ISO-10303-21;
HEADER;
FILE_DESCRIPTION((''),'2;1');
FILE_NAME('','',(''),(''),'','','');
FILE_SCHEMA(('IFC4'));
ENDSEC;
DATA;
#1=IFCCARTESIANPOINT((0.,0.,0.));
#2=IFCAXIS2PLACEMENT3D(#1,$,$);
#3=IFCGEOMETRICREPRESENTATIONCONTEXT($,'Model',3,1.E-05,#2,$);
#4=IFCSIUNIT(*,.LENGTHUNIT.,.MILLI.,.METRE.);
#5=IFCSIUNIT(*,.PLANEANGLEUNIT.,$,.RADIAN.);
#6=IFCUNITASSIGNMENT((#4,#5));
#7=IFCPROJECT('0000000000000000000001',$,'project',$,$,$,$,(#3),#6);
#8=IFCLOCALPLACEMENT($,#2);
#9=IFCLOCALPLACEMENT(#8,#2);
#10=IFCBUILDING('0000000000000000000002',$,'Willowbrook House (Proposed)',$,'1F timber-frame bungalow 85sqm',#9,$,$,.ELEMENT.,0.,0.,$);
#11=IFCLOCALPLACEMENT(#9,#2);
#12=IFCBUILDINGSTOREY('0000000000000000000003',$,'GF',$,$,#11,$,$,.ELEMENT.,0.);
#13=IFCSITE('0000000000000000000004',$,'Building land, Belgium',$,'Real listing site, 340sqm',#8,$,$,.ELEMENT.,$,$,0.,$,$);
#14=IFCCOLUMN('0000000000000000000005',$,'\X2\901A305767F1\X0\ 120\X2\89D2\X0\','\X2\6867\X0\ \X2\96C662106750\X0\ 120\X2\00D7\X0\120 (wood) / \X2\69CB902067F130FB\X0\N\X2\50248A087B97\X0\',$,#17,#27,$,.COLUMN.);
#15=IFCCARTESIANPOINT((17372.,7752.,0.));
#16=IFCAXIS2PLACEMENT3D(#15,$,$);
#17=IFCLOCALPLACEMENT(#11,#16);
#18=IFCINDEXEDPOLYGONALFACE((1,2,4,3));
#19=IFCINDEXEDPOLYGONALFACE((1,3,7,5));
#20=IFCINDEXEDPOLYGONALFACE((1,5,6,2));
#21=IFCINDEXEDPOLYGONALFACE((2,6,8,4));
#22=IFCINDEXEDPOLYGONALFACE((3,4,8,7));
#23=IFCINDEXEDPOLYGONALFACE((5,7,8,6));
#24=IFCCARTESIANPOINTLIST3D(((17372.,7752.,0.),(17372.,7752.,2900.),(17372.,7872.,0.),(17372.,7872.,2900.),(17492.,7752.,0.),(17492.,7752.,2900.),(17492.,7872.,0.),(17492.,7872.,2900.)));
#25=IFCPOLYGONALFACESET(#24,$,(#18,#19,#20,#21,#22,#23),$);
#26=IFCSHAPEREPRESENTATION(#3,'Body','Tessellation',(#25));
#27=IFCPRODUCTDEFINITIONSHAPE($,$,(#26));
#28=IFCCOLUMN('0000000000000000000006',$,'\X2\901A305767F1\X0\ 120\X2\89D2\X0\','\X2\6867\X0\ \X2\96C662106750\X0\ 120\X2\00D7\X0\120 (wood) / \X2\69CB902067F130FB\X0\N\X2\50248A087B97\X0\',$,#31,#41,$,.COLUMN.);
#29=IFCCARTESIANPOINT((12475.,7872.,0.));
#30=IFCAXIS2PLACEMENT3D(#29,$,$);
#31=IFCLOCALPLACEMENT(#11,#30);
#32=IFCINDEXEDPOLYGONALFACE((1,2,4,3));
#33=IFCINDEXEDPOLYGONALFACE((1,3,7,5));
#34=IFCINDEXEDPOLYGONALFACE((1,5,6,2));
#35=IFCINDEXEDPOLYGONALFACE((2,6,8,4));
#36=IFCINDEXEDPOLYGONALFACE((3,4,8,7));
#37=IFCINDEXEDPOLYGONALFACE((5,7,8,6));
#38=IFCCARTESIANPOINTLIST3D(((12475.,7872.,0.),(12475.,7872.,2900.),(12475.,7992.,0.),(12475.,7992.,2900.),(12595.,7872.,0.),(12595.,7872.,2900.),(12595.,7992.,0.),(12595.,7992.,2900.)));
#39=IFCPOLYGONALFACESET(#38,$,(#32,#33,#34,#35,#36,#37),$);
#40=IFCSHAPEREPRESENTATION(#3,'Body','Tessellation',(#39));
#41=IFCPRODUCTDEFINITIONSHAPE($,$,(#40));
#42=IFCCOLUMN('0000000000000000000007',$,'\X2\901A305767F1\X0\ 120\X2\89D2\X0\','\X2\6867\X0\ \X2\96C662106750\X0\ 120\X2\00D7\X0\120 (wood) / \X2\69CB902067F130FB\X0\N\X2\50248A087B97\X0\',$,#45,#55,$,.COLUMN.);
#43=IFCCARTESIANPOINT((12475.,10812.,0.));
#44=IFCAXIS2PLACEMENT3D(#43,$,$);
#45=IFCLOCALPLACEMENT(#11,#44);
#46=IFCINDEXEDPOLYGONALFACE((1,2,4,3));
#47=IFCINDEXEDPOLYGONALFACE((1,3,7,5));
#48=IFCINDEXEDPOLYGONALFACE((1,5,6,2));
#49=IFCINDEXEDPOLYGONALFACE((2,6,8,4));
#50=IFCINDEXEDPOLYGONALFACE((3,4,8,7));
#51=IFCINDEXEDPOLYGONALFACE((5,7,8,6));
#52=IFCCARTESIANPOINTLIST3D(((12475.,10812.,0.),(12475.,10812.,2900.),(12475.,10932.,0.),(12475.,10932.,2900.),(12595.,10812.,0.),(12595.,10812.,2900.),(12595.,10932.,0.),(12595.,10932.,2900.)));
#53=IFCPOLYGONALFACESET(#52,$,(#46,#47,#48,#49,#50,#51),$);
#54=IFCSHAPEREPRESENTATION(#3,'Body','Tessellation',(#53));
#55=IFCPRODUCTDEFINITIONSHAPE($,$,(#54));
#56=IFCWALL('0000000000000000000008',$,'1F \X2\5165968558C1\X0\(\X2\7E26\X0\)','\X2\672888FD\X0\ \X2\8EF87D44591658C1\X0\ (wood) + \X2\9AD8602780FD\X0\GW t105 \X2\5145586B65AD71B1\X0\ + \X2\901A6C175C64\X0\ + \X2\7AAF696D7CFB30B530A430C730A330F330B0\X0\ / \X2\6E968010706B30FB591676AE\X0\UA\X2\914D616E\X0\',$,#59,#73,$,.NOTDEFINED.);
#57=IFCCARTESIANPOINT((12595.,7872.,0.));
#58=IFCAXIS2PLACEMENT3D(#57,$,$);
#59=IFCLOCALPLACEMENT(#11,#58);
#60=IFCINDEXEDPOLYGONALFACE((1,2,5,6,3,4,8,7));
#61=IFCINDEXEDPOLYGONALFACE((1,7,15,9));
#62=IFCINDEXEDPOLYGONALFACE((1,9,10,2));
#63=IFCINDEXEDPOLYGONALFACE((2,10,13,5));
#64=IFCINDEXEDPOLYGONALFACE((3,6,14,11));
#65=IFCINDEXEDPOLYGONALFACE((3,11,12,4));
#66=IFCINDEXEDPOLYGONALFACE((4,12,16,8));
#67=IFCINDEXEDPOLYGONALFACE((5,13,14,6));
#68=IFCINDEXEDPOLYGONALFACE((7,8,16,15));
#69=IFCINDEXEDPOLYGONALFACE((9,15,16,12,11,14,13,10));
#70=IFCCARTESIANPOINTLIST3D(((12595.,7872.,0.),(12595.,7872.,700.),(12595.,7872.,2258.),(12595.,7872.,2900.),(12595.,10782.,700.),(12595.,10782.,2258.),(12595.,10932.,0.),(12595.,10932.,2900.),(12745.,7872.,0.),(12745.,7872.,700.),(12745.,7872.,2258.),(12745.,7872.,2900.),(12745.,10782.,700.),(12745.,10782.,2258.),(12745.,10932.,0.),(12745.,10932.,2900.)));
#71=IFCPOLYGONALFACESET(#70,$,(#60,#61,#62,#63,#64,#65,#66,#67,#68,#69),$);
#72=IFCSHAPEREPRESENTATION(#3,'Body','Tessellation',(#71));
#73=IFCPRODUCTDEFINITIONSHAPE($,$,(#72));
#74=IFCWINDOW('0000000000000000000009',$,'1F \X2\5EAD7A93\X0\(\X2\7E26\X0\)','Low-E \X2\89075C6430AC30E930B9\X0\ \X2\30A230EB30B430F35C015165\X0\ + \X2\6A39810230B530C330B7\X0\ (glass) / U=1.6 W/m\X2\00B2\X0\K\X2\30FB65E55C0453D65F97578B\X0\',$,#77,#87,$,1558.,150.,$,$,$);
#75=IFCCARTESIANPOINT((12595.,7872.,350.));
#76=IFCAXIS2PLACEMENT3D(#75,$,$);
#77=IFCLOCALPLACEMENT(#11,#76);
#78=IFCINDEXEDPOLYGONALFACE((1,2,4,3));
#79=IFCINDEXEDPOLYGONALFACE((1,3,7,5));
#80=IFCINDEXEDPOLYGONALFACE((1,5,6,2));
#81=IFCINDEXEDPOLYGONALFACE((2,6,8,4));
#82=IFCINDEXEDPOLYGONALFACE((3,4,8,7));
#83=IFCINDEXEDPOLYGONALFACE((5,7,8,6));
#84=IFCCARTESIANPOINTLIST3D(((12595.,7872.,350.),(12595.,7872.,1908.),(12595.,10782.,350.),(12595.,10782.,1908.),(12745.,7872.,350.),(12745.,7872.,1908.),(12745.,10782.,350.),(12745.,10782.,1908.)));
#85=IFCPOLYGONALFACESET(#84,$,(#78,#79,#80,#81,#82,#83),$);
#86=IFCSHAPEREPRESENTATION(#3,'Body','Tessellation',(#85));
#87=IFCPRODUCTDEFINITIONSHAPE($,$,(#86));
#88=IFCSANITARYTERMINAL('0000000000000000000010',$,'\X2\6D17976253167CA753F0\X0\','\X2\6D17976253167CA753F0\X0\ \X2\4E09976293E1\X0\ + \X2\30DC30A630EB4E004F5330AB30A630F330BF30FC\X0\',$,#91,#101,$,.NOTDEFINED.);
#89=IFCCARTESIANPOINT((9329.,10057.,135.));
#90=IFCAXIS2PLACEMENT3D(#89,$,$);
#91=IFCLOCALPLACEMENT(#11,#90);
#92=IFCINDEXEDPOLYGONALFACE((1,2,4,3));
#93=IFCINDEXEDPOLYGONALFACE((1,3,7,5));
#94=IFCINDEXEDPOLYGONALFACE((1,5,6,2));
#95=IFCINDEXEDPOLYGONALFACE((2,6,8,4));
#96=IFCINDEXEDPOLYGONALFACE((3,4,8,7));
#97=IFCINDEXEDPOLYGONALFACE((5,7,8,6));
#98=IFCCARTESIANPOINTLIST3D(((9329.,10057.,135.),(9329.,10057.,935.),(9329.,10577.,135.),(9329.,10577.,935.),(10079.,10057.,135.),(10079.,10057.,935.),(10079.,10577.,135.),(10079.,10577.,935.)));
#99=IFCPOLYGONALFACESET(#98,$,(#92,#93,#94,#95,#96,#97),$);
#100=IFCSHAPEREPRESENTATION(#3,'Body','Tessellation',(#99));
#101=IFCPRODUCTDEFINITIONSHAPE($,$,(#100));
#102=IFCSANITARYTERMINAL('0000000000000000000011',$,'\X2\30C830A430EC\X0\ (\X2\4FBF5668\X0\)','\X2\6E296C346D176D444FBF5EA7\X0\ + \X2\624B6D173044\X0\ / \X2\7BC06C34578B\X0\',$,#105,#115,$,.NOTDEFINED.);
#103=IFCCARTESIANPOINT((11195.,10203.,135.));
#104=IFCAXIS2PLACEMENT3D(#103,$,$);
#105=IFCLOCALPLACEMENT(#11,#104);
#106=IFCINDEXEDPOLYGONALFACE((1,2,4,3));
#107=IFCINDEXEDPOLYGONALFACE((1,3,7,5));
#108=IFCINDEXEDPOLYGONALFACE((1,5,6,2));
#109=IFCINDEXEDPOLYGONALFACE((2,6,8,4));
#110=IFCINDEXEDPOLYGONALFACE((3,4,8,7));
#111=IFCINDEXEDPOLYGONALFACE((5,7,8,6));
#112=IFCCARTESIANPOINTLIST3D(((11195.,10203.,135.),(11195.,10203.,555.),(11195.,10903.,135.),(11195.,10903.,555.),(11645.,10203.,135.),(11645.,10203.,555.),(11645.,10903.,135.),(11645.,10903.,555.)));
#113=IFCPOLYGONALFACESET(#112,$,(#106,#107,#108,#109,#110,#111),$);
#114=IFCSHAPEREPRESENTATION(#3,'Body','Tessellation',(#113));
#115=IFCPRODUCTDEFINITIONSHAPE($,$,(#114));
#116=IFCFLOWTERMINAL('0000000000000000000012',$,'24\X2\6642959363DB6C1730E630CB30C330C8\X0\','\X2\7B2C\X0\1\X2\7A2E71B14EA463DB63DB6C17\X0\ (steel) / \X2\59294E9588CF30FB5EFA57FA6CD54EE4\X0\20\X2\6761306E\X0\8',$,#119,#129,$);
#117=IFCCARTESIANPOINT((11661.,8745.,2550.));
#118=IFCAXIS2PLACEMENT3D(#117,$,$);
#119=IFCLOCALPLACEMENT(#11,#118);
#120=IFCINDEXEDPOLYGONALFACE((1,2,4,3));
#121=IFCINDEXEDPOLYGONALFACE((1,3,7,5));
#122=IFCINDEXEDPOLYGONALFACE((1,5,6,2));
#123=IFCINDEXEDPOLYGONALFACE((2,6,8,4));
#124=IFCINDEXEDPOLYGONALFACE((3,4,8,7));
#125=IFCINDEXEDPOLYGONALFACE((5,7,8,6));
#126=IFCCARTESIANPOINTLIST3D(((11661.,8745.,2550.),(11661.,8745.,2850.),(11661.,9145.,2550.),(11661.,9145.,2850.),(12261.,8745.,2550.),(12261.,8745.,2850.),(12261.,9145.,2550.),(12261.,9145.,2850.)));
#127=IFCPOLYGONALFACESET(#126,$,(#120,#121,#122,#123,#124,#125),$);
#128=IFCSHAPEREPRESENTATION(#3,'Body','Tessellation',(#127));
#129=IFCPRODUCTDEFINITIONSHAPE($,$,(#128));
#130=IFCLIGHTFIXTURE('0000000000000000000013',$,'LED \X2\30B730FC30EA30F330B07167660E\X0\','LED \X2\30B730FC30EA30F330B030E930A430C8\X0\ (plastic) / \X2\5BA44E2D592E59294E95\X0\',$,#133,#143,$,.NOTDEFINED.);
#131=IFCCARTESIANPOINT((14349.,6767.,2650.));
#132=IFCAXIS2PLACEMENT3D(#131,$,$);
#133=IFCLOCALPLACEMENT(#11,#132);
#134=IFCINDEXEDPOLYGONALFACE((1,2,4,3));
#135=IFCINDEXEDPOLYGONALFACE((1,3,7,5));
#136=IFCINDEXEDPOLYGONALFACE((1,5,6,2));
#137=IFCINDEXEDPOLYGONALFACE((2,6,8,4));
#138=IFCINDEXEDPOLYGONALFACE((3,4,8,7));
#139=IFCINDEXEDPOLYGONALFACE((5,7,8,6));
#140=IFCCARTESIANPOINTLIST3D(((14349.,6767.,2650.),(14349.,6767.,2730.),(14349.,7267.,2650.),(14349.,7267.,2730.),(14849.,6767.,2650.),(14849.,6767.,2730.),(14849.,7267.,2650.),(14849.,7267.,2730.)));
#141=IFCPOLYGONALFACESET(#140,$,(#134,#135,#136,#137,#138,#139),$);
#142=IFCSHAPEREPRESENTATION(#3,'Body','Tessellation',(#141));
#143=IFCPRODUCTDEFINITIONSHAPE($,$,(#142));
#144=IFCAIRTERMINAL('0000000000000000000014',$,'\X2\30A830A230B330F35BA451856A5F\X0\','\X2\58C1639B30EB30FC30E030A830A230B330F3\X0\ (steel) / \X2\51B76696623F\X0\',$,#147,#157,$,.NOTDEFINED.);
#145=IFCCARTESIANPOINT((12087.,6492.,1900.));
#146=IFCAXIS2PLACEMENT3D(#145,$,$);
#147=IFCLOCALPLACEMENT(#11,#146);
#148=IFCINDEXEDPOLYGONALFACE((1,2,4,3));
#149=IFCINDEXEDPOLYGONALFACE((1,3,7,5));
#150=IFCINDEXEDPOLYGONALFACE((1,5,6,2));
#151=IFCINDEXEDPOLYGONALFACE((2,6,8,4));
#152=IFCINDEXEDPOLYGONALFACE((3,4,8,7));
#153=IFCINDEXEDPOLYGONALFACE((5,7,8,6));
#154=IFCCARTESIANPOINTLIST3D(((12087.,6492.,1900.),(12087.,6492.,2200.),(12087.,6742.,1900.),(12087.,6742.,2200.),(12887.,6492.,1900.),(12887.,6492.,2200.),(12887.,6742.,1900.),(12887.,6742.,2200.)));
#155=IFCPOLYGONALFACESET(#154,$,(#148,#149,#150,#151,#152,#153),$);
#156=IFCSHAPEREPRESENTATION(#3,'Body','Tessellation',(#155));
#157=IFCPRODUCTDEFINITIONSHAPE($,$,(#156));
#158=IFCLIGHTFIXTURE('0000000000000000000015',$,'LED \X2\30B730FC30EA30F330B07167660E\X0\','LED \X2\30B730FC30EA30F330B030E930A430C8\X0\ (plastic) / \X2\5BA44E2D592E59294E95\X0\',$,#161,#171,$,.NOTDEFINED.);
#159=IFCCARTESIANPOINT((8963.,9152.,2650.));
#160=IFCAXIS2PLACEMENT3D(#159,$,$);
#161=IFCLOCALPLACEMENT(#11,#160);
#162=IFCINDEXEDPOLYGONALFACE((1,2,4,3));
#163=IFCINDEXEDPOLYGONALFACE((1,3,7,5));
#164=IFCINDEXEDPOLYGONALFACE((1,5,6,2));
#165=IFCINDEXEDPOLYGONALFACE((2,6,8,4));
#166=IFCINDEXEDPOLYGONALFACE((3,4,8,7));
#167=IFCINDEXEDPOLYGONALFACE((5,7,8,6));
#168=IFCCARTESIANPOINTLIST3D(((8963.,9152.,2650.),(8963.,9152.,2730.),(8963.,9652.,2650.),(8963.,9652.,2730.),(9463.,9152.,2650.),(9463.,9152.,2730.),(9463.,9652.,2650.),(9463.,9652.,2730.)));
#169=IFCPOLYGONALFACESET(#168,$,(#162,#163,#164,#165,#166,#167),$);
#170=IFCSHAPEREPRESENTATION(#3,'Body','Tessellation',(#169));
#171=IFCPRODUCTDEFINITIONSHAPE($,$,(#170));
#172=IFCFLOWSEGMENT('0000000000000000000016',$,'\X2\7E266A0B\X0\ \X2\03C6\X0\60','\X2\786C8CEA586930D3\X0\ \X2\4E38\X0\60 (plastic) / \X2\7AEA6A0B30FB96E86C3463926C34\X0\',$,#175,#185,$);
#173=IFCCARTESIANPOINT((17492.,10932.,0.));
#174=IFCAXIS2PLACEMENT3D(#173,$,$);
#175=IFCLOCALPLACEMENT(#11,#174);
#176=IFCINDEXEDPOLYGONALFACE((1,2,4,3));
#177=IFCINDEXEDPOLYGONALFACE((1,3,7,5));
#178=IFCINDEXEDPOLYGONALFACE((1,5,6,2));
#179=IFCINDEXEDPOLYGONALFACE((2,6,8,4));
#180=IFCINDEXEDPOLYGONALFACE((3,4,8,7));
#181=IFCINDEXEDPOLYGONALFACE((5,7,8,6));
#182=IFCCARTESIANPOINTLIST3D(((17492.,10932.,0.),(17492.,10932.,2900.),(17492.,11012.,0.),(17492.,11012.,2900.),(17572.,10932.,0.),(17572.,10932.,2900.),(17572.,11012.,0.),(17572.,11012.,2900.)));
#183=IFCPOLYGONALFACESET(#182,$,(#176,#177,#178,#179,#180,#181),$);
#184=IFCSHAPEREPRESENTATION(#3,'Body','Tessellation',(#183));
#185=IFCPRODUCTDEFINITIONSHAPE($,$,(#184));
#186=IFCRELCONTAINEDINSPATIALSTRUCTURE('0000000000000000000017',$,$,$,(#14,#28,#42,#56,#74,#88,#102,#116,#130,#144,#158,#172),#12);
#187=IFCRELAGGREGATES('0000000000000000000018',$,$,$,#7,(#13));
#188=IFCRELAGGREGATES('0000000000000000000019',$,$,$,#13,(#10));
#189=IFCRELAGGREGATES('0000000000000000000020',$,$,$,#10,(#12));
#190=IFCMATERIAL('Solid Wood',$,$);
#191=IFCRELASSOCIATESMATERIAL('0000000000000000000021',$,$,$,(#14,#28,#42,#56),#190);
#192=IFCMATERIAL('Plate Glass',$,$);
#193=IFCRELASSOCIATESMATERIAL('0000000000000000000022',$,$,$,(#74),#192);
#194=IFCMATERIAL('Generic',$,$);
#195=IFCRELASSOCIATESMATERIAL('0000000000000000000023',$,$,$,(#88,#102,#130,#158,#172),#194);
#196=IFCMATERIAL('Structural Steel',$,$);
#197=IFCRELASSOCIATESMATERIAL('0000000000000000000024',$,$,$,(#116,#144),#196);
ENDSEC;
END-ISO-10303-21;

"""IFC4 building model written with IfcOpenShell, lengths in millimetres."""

from ifc_helpers import new_model, si_unit, frame, frame_2d, origin, place, context, project, spatial, rectangle, extrude, material, element, fill, save


model = new_model("IFC4")

# Units and contexts
model_context = context("Model", 3, precision=1e-05, world=origin())
ifc_project = project(units=[si_unit("LENGTHUNIT", "METRE", prefix="MILLI"), si_unit("PLANEANGLEUNIT", "RADIAN")], contexts=[model_context])

# Site, building, storey
site_placement = place(None, origin())
site = spatial("IfcSite", under=ifc_project, at=site_placement, Name="Building land, Belgium", ObjectType="Real listing site, 340sqm", CompositionType="ELEMENT", RefElevation=0.0)
building_placement = place(site_placement, origin())
building = spatial("IfcBuilding", under=site, at=building_placement, Name="Willowbrook House (Proposed)", ObjectType="1F timber-frame bungalow 85sqm", CompositionType="ELEMENT", ElevationOfRefHeight=0.0, ElevationOfTerrain=0.0)
storey_placement = place(building_placement, origin())
storey = spatial("IfcBuildingStorey", under=building, at=storey_placement, Name="GF", CompositionType="ELEMENT", Elevation=0.0)

# Columns
ifc_material_1 = material(Name="Solid Wood")
column_1_placement = place(storey_placement, frame((17372.0, 7752.0, 0.0)))
element("IfcColumn", 1, at=column_1_placement, inside=storey, material=ifc_material_1, Name="通し柱 120角", Description="桧 集成材 120×120 (wood) / 構造柱・N値計算", PredefinedType="COLUMN", context=model_context, shape_type="SweptSolid", body=[
    extrude(rectangle(XDim=120.0, YDim=120.0, at=frame_2d((60.0, 60.0))), frame((17372.0, 7752.0, 0.0)), (0.0, 0.0, 1.0), 2900.0),
])
column_2_placement = place(storey_placement, frame((12475.0, 7872.0, 0.0)))
element("IfcColumn", 2, at=column_2_placement, inside=storey, material=ifc_material_1, Name="通し柱 120角", Description="桧 集成材 120×120 (wood) / 構造柱・N値計算", PredefinedType="COLUMN", context=model_context, shape_type="SweptSolid", body=[
    extrude(rectangle(XDim=120.0, YDim=120.0, at=frame_2d((60.0, 60.0))), frame((12475.0, 7872.0, 0.0)), (0.0, 0.0, 1.0), 2900.0),
])
column_3_placement = place(storey_placement, frame((12475.0, 10812.0, 0.0)))
element("IfcColumn", 3, at=column_3_placement, inside=storey, material=ifc_material_1, Name="通し柱 120角", Description="桧 集成材 120×120 (wood) / 構造柱・N値計算", PredefinedType="COLUMN", context=model_context, shape_type="SweptSolid", body=[
    extrude(rectangle(XDim=120.0, YDim=120.0, at=frame_2d((60.0, 60.0))), frame((12475.0, 10812.0, 0.0)), (0.0, 0.0, 1.0), 2900.0),
])

# Wall, opening, window
wall_1_placement = place(storey_placement, frame((12595.0, 7872.0, 0.0)))
wall_1 = element("IfcWall", 4, at=wall_1_placement, inside=storey, material=ifc_material_1, Name="1F 入隅壁(縦)", Description="木製 軸組外壁 (wood) + 高性能GW t105 充填断熱 + 通気層 + 窯業系サイディング / 準耐火・外皮UA配慮", PredefinedType="NOTDEFINED", context=model_context, shape_type="SweptSolid", body=[
    extrude(rectangle(XDim=150.0, YDim=3060.0, at=frame_2d((75.0, 1530.0))), frame((12595.0, 7872.0, 0.0)), (0.0, 0.0, 1.0), 2900.0),
])
opening_placement = place(storey_placement, frame((12595.0, 7872.0, 350.0)))
opening = element("IfcOpeningElement", 5, at=opening_placement, cuts=wall_1, PredefinedType="NOTDEFINED", context=model_context, shape_type="SweptSolid", body=[
    extrude(rectangle(XDim=150.0, YDim=2910.0, at=frame_2d((75.0, 1455.0))), frame((12595.0, 7872.0, 350.0)), (0.0, 0.0, 1.0), 1558.0),
])
ifc_material_2 = material(Name="Plate Glass")
window_placement = place(storey_placement, frame((12595.0, 7872.0, 350.0)))
window = element("IfcWindow", 6, at=window_placement, inside=storey, material=ifc_material_2, Name="1F 庭窓(縦)", Description="Low-E 複層ガラス アルゴン封入 + 樹脂サッシ (glass) / U=1.6 W/m²K・日射取得型", OverallHeight=1558.0, OverallWidth=150.0, context=model_context, shape_type="SweptSolid", body=[
    extrude(rectangle(XDim=150.0, YDim=2910.0, at=frame_2d((75.0, 1455.0))), frame((12595.0, 7872.0, 350.0)), (0.0, 0.0, 1.0), 1558.0),
])
fill(opening, window)

# Sanitary terminals
ifc_material_3 = material(Name="Generic")
sanitary_terminal_1_placement = place(storey_placement, frame((9329.0, 10057.0, 135.0)))
element("IfcSanitaryTerminal", 7, at=sanitary_terminal_1_placement, inside=storey, material=ifc_material_3, Name="洗面化粧台", Description="洗面化粧台 三面鏡 + ボウル一体カウンター", PredefinedType="NOTDEFINED", context=model_context, shape_type="SweptSolid", body=[
    extrude(rectangle(XDim=750.0, YDim=520.0, at=frame_2d((375.0, 260.0))), frame((9329.0, 10057.0, 135.0)), (0.0, 0.0, 1.0), 800.0),
])
sanitary_terminal_2_placement = place(storey_placement, frame((11195.0, 10203.0, 135.0)))
element("IfcSanitaryTerminal", 8, at=sanitary_terminal_2_placement, inside=storey, material=ifc_material_3, Name="トイレ (便器)", Description="温水洗浄便座 + 手洗い / 節水型", PredefinedType="NOTDEFINED", context=model_context, shape_type="SweptSolid", body=[
    extrude(rectangle(XDim=450.0, YDim=700.0, at=frame_2d((225.0, 350.0))), frame((11195.0, 10203.0, 135.0)), (0.0, 0.0, 1.0), 420.0),
])

# Flow terminal
ifc_material_4 = material(Name="Structural Steel")
flow_terminal_placement = place(storey_placement, frame((11661.0, 8745.0, 2550.0)))
element("IfcFlowTerminal", 9, at=flow_terminal_placement, inside=storey, material=ifc_material_4, Name="24時間換気ユニット", Description="第1種熱交換換気 (steel) / 天井裏・建基法令20条の8", context=model_context, shape_type="SweptSolid", body=[
    extrude(rectangle(XDim=600.0, YDim=400.0, at=frame_2d((300.0, 200.0))), frame((11661.0, 8745.0, 2550.0)), (0.0, 0.0, 1.0), 300.0),
])

# Light fixture
light_fixture_1_placement = place(storey_placement, frame((14349.0, 6767.0, 2650.0)))
element("IfcLightFixture", 10, at=light_fixture_1_placement, inside=storey, material=ifc_material_3, Name="LED シーリング照明", Description="LED シーリングライト (plastic) / 室中央天井", PredefinedType="NOTDEFINED", context=model_context, shape_type="SweptSolid", body=[
    extrude(rectangle(XDim=500.0, YDim=500.0, at=frame_2d((250.0, 250.0))), frame((14349.0, 6767.0, 2650.0)), (0.0, 0.0, 1.0), 80.0),
])

# Air terminal
air_terminal_placement = place(storey_placement, frame((12087.0, 6492.0, 1900.0)))
element("IfcAirTerminal", 11, at=air_terminal_placement, inside=storey, material=ifc_material_4, Name="エアコン室内機", Description="壁掛ルームエアコン (steel) / 冷暖房", PredefinedType="NOTDEFINED", context=model_context, shape_type="SweptSolid", body=[
    extrude(rectangle(XDim=800.0, YDim=250.0, at=frame_2d((400.0, 125.0))), frame((12087.0, 6492.0, 1900.0)), (0.0, 0.0, 1.0), 300.0),
])

# Light fixture
light_fixture_2_placement = place(storey_placement, frame((8963.0, 9152.0, 2650.0)))
element("IfcLightFixture", 12, at=light_fixture_2_placement, inside=storey, material=ifc_material_3, Name="LED シーリング照明", Description="LED シーリングライト (plastic) / 室中央天井", PredefinedType="NOTDEFINED", context=model_context, shape_type="SweptSolid", body=[
    extrude(rectangle(XDim=500.0, YDim=500.0, at=frame_2d((250.0, 250.0))), frame((8963.0, 9152.0, 2650.0)), (0.0, 0.0, 1.0), 80.0),
])

# Flow segment
flow_segment_placement = place(storey_placement, frame((17492.0, 10932.0, 0.0)))
element("IfcFlowSegment", 13, at=flow_segment_placement, inside=storey, material=ifc_material_3, Name="縦樋 φ60", Description="硬質塩ビ 丸60 (plastic) / 竪樋・雨水排水", context=model_context, shape_type="SweptSolid", body=[
    extrude(rectangle(XDim=80.0, YDim=80.0, at=frame_2d((40.0, 40.0))), frame((17492.0, 10932.0, 0.0)), (0.0, 0.0, 1.0), 2900.0),
])

save(model, "model.ifc")
